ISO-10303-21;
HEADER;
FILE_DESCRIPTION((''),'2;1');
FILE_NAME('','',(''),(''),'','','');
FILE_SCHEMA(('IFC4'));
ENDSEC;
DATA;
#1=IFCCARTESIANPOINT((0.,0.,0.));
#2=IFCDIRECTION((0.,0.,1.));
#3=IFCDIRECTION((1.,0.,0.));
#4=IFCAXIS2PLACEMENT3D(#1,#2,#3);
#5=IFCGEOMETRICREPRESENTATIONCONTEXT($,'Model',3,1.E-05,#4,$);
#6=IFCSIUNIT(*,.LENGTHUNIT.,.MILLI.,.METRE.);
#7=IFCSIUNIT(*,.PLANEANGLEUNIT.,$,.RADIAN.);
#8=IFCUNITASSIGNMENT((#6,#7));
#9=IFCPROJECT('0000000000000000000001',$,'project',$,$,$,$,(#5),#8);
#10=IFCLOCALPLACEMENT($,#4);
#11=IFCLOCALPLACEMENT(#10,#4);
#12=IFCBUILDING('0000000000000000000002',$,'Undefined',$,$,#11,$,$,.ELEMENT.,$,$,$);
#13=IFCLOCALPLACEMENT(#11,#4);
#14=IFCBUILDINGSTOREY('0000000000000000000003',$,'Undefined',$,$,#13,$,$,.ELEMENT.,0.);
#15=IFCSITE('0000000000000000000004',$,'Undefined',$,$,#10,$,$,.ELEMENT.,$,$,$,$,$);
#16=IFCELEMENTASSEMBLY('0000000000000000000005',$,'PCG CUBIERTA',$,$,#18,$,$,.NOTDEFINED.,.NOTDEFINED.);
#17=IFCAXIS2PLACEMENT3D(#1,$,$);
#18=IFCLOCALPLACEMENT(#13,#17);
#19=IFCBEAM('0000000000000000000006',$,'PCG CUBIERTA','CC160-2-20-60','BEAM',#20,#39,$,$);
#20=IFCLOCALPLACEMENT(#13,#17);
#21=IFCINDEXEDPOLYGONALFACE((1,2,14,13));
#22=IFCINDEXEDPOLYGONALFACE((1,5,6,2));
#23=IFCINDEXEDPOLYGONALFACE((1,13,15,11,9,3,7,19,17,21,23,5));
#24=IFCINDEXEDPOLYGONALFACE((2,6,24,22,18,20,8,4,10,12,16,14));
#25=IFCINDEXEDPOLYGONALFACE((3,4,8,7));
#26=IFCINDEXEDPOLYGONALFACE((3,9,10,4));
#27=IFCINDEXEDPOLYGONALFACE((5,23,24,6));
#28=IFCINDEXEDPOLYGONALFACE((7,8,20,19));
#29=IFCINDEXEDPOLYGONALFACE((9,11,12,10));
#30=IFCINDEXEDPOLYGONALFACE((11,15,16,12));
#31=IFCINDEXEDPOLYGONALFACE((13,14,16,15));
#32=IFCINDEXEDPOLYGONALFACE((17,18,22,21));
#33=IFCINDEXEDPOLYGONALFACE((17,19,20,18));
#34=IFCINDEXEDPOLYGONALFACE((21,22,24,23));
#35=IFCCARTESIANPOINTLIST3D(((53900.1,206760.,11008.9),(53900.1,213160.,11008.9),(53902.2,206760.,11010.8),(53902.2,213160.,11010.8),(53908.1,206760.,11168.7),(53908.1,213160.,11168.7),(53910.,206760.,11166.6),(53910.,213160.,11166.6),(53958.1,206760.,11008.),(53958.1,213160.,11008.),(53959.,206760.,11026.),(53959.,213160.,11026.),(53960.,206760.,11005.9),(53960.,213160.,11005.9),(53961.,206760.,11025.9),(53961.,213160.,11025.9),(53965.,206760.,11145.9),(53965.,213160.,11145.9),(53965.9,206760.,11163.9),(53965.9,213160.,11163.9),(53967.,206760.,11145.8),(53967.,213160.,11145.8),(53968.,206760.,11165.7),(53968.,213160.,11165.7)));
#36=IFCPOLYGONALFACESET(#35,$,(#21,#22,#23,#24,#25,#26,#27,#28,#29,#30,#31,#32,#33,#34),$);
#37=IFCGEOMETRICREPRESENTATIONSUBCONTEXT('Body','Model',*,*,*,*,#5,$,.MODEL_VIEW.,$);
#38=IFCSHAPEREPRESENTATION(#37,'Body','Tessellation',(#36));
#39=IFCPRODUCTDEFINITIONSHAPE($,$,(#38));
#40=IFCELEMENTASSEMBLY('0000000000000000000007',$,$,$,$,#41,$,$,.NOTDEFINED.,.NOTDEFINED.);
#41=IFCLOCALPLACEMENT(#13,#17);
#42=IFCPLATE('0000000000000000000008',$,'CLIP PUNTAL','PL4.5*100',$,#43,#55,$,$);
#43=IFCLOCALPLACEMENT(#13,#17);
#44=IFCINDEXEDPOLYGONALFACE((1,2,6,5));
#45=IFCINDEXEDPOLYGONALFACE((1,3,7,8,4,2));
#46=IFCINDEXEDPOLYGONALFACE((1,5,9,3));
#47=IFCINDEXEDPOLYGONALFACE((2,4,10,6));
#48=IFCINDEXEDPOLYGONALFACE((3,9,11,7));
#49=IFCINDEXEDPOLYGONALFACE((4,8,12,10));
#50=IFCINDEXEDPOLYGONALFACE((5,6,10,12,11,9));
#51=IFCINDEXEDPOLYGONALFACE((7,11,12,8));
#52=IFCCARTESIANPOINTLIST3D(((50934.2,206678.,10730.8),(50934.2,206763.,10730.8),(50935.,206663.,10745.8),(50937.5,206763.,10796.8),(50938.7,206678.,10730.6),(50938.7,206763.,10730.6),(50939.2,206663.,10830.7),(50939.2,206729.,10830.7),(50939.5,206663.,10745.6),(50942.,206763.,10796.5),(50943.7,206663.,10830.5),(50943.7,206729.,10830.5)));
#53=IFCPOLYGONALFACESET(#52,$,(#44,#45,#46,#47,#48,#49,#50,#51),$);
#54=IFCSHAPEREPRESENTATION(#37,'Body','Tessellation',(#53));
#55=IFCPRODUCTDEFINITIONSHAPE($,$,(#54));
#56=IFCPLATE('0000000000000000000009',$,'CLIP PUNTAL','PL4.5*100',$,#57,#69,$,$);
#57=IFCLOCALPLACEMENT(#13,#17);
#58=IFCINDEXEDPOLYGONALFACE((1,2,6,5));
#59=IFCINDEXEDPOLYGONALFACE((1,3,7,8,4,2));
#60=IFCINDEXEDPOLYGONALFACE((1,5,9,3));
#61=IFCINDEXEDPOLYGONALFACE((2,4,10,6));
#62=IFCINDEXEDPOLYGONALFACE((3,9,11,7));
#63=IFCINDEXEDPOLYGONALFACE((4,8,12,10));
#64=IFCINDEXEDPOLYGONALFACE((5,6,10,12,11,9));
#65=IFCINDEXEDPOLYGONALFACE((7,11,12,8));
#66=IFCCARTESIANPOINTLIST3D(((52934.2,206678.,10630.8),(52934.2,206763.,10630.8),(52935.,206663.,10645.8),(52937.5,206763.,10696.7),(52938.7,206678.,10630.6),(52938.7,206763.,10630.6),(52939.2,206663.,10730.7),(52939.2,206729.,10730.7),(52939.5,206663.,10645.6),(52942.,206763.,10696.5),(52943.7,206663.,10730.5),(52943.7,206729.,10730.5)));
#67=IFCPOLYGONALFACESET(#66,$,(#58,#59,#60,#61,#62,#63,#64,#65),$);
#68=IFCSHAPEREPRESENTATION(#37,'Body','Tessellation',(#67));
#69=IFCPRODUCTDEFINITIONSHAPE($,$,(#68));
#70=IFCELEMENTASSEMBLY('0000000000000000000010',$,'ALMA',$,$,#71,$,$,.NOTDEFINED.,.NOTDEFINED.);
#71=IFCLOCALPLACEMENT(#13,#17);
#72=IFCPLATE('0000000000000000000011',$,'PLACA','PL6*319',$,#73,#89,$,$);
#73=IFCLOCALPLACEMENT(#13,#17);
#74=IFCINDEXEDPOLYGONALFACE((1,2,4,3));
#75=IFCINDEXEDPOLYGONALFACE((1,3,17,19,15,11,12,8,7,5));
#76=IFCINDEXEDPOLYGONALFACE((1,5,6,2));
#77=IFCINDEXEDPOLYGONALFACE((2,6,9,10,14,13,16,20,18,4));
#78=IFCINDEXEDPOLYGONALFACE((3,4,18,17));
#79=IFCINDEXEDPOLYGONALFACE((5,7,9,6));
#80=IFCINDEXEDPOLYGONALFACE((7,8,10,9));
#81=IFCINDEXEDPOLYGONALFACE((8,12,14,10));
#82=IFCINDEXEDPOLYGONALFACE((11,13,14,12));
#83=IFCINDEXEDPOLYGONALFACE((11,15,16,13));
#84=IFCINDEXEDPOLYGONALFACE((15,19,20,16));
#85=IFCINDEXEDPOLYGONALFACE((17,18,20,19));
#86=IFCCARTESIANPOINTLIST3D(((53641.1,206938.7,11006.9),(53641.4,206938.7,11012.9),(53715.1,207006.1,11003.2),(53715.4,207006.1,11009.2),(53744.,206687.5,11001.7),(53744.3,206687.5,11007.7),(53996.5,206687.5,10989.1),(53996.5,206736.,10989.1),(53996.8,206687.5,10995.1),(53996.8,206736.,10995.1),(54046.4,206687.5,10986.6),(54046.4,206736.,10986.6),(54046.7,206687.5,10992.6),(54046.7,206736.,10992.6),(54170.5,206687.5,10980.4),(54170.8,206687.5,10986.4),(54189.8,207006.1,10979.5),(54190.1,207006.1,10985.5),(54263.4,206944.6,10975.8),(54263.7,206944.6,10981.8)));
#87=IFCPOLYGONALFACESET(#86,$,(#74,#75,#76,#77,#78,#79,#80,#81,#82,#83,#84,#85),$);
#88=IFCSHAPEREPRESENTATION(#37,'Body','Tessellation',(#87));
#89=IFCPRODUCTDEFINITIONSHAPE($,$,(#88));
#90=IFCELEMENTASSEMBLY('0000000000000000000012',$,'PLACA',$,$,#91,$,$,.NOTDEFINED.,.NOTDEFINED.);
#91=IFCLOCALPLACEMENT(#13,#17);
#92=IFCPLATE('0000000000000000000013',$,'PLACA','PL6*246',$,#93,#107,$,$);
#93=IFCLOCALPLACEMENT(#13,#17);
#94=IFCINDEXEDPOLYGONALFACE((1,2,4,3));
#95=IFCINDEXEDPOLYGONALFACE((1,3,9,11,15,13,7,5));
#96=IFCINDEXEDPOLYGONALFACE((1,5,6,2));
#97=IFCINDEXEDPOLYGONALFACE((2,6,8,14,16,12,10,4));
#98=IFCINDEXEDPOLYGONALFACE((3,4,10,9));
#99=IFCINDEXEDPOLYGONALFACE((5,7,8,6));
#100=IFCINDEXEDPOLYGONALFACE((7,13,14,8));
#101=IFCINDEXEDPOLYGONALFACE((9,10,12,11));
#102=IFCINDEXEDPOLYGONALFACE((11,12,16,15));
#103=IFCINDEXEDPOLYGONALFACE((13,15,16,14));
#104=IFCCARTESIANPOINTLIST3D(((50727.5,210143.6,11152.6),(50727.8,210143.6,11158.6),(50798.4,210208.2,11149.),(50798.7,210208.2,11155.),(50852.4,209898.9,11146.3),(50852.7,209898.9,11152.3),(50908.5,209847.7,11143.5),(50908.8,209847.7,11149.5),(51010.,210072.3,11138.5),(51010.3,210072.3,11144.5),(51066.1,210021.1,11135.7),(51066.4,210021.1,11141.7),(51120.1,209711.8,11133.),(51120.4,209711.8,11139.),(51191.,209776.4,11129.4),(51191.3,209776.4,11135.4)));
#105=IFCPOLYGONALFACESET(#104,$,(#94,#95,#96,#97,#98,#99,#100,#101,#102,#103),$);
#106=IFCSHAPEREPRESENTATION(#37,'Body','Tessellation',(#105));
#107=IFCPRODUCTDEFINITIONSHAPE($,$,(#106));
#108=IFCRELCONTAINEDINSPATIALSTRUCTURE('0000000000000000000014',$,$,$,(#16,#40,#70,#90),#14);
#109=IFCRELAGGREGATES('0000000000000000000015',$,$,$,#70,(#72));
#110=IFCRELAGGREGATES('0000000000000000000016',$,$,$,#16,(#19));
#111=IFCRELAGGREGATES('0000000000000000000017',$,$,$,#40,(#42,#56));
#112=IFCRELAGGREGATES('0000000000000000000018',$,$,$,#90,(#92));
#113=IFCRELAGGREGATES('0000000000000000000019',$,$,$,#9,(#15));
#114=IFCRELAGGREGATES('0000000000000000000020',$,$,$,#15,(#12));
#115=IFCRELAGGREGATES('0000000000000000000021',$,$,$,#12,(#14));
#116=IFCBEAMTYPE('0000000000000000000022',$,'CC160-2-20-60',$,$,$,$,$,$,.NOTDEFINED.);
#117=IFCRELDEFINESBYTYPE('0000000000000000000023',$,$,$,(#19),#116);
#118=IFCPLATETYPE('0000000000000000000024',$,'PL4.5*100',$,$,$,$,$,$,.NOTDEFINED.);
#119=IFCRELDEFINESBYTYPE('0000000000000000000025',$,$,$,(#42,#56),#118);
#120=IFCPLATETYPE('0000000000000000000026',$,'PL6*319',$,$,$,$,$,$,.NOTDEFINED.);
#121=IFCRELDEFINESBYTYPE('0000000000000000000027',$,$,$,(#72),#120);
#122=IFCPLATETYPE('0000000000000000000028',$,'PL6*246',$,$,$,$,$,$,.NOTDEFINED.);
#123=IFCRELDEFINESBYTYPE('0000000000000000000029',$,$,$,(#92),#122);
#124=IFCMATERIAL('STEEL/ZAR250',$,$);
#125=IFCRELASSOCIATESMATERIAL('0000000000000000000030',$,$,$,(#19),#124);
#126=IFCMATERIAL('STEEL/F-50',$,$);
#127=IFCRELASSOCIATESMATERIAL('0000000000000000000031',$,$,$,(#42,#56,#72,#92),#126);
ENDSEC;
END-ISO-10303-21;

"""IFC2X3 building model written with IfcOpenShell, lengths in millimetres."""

from ifc_helpers import new_model, si_unit, frame, origin_with_axes, origin_2d_with_axis, place, context, subcontext, project, spatial, polyline, c_section, outline, extrude, boolean, material, type_object, element, aggregate, save


model = new_model("IFC2X3")

# Units and contexts
model_context = context("Model", 3, precision=1e-05, world=origin_with_axes())
body_context = subcontext(model_context, "Body", "Model", "MODEL_VIEW")
ifc_project = project(units=[si_unit("LENGTHUNIT", "METRE", prefix="MILLI"), si_unit("PLANEANGLEUNIT", "RADIAN")], contexts=[model_context])

# Site, building, storey
site_placement = place(None, origin_with_axes())
site = spatial("IfcSite", under=ifc_project, at=site_placement, Name="Undefined", CompositionType="ELEMENT")
building_placement = place(site_placement, origin_with_axes())
building = spatial("IfcBuilding", under=site, at=building_placement, Name="Undefined", CompositionType="ELEMENT")
storey_placement = place(building_placement, origin_with_axes())
storey = spatial("IfcBuildingStorey", under=building, at=storey_placement, Name="Undefined", CompositionType="ELEMENT", Elevation=0.0)

# Element assembly, beam
assembly_1_placement = place(storey_placement, origin_with_axes())
assembly_1 = element("IfcElementAssembly", 1, at=assembly_1_placement, inside=storey, Name="PCG CUBIERTA", AssemblyPlace="NOTDEFINED", PredefinedType="NOTDEFINED")
ifc_material_1 = material(Name="STEEL/ZAR250")
beam_type_1 = type_object("IfcBeamType", Name="CC160-2-20-60", PredefinedType="NOTDEFINED")
beam_1_placement = place(assembly_1_placement, frame((53934.0, 206760.0, 11087.3), z_axis=(0.049943, 0.0, 0.998752), x_axis=(0.0, 1.0, 0.0)))
beam_1 = element("IfcBeam", 2, at=beam_1_placement, type_object=beam_type_1, material=ifc_material_1, Name="PCG CUBIERTA", Description="CC160-2-20-60", ObjectType="BEAM", context=body_context, shape_type="SweptSolid", body=[
    extrude(c_section(Depth=160.0, Width=60.0, WallThickness=2.0, Girth=20.0, at=origin_2d_with_axis()), frame((6400.0, 0.0, 0.0), z_axis=(-1.0, 0.0, 0.0), x_axis=(0.0, -1.0, 0.0)), (0.0, 0.0, 1.0), 6400.0),
])

# Element assembly, plates
assembly_2_placement = place(storey_placement, origin_with_axes())
assembly_2 = element("IfcElementAssembly", 3, at=assembly_2_placement, inside=storey, AssemblyPlace="NOTDEFINED", PredefinedType="NOTDEFINED")
ifc_material_2 = material(Name="STEEL/F-50")
plate_type_1 = type_object("IfcPlateType", Name="PL4.5*100", PredefinedType="NOTDEFINED")
plate_1_placement = place(assembly_2_placement, frame((50941.5, 206663.0, 10830.6), z_axis=(-0.998754, 0.0, 0.049896), x_axis=(0.0, 1.0, 0.0)))
plate_1 = element("IfcPlate", 4, at=plate_1_placement, type_object=plate_type_1, material=ifc_material_2, Name="CLIP PUNTAL", Description="PL4.5*100", context=body_context, shape_type="SweptSolid", body=[
    extrude(outline(polyline([(0.0, 0.0), (66.0, 0.0), (100.0, 34.0), (100.0, 100.0), (15.0, 100.0), (0.0, 85.0), (0.0, 0.0)])), frame((0.0, 0.0, -2.2), z_axis=(0.0, 0.0, 1.0), x_axis=(1.0, 0.0, 0.0)), (0.0, 0.0, 1.0), 4.5),
])
plate_2_placement = place(assembly_2_placement, frame((52941.5, 206663.0, 10730.6), z_axis=(-0.998754, 0.0, 0.049896), x_axis=(0.0, 1.0, 0.0)))
plate_2 = element("IfcPlate", 5, at=plate_2_placement, type_object=plate_type_1, material=ifc_material_2, Name="CLIP PUNTAL", Description="PL4.5*100", context=body_context, shape_type="SweptSolid", body=[
    extrude(outline(polyline([(0.0, 0.0), (66.0, 0.0), (100.0, 34.0), (100.0, 100.0), (15.0, 100.0), (0.0, 85.0), (0.0, 0.0)])), frame((0.0, 0.0, -2.2), z_axis=(0.0, 0.0, 1.0), x_axis=(1.0, 0.0, 0.0)), (0.0, 0.0, 1.0), 4.5),
])

# Element assemblies, plates
assembly_3_placement = place(storey_placement, origin_with_axes())
assembly_3 = element("IfcElementAssembly", 6, at=assembly_3_placement, inside=storey, Name="ALMA", AssemblyPlace="NOTDEFINED", PredefinedType="NOTDEFINED")
plate_type_2 = type_object("IfcPlateType", Name="PL6*319", PredefinedType="NOTDEFINED")
plate_3_placement = place(assembly_3_placement, frame((53744.2, 206687.5, 11004.7), z_axis=(0.049943, 0.0, 0.998752), x_axis=(0.998752, 0.0, -0.049943)))
plate_3 = element("IfcPlate", 7, at=plate_3_placement, type_object=plate_type_2, material=ifc_material_2, Name="PLACA", Description="PL6*319", context=body_context, shape_type="CSG", body=[
    boolean("DIFFERENCE", extrude(outline(polyline([(0.0, 0.0), (427.0, 0.0), (520.0, 257.1), (446.3, 318.6), (-29.0, 318.6), (-103.1, 251.2), (0.0, 0.0)])), frame((0.0, 0.0, -3.0), z_axis=(0.0, 0.0, 1.0), x_axis=(1.0, 0.0, 0.0)), (0.0, 0.0, 1.0), 6.0), extrude(outline(polyline([(0.0, 0.0), (60.0, 0.0), (60.0, 50.0), (0.0, 50.0), (0.0, 0.0)])), frame((252.8, -11.5, 6.0), z_axis=(0.0, 0.0, -1.0), x_axis=(0.0, 1.0, 0.0)), (0.0, 0.0, 1.0), 12.0)),
])
aggregate(assembly_3, [plate_3])
assembly_4_placement = place(storey_placement, origin_with_axes())
assembly_4 = element("IfcElementAssembly", 8, at=assembly_4_placement, inside=storey, Name="PLACA", AssemblyPlace="NOTDEFINED", PredefinedType="NOTDEFINED")
plate_type_3 = type_object("IfcPlateType", Name="PL6*246", PredefinedType="NOTDEFINED")
plate_4_placement = place(assembly_4_placement, frame((50852.5, 209898.9, 11149.3), z_axis=(0.049943, 0.0, 0.998752), x_axis=(0.738599, -0.673133, -0.036934)))
plate_4 = element("IfcPlate", 9, at=plate_4_placement, type_object=plate_type_3, material=ifc_material_2, Name="PLACA", Description="PL6*246", context=body_context, shape_type="SweptSolid", body=[
    extrude(outline(polyline([(0.0, 0.0), (76.0, 0.0), (324.2, 42.1), (333.2, 137.6), (76.0, 234.5), (0.0, 234.5), (-248.2, 192.4), (-257.2, 96.8), (0.0, 0.0)])), frame((0.0, 0.0, -3.0), z_axis=(0.0, 0.0, 1.0), x_axis=(1.0, 0.0, 0.0)), (0.0, 0.0, 1.0), 6.0),
])

aggregate(assembly_1, [beam_1])

aggregate(assembly_2, [plate_1, plate_2])

aggregate(assembly_4, [plate_4])

save(model, "model.ifc")
